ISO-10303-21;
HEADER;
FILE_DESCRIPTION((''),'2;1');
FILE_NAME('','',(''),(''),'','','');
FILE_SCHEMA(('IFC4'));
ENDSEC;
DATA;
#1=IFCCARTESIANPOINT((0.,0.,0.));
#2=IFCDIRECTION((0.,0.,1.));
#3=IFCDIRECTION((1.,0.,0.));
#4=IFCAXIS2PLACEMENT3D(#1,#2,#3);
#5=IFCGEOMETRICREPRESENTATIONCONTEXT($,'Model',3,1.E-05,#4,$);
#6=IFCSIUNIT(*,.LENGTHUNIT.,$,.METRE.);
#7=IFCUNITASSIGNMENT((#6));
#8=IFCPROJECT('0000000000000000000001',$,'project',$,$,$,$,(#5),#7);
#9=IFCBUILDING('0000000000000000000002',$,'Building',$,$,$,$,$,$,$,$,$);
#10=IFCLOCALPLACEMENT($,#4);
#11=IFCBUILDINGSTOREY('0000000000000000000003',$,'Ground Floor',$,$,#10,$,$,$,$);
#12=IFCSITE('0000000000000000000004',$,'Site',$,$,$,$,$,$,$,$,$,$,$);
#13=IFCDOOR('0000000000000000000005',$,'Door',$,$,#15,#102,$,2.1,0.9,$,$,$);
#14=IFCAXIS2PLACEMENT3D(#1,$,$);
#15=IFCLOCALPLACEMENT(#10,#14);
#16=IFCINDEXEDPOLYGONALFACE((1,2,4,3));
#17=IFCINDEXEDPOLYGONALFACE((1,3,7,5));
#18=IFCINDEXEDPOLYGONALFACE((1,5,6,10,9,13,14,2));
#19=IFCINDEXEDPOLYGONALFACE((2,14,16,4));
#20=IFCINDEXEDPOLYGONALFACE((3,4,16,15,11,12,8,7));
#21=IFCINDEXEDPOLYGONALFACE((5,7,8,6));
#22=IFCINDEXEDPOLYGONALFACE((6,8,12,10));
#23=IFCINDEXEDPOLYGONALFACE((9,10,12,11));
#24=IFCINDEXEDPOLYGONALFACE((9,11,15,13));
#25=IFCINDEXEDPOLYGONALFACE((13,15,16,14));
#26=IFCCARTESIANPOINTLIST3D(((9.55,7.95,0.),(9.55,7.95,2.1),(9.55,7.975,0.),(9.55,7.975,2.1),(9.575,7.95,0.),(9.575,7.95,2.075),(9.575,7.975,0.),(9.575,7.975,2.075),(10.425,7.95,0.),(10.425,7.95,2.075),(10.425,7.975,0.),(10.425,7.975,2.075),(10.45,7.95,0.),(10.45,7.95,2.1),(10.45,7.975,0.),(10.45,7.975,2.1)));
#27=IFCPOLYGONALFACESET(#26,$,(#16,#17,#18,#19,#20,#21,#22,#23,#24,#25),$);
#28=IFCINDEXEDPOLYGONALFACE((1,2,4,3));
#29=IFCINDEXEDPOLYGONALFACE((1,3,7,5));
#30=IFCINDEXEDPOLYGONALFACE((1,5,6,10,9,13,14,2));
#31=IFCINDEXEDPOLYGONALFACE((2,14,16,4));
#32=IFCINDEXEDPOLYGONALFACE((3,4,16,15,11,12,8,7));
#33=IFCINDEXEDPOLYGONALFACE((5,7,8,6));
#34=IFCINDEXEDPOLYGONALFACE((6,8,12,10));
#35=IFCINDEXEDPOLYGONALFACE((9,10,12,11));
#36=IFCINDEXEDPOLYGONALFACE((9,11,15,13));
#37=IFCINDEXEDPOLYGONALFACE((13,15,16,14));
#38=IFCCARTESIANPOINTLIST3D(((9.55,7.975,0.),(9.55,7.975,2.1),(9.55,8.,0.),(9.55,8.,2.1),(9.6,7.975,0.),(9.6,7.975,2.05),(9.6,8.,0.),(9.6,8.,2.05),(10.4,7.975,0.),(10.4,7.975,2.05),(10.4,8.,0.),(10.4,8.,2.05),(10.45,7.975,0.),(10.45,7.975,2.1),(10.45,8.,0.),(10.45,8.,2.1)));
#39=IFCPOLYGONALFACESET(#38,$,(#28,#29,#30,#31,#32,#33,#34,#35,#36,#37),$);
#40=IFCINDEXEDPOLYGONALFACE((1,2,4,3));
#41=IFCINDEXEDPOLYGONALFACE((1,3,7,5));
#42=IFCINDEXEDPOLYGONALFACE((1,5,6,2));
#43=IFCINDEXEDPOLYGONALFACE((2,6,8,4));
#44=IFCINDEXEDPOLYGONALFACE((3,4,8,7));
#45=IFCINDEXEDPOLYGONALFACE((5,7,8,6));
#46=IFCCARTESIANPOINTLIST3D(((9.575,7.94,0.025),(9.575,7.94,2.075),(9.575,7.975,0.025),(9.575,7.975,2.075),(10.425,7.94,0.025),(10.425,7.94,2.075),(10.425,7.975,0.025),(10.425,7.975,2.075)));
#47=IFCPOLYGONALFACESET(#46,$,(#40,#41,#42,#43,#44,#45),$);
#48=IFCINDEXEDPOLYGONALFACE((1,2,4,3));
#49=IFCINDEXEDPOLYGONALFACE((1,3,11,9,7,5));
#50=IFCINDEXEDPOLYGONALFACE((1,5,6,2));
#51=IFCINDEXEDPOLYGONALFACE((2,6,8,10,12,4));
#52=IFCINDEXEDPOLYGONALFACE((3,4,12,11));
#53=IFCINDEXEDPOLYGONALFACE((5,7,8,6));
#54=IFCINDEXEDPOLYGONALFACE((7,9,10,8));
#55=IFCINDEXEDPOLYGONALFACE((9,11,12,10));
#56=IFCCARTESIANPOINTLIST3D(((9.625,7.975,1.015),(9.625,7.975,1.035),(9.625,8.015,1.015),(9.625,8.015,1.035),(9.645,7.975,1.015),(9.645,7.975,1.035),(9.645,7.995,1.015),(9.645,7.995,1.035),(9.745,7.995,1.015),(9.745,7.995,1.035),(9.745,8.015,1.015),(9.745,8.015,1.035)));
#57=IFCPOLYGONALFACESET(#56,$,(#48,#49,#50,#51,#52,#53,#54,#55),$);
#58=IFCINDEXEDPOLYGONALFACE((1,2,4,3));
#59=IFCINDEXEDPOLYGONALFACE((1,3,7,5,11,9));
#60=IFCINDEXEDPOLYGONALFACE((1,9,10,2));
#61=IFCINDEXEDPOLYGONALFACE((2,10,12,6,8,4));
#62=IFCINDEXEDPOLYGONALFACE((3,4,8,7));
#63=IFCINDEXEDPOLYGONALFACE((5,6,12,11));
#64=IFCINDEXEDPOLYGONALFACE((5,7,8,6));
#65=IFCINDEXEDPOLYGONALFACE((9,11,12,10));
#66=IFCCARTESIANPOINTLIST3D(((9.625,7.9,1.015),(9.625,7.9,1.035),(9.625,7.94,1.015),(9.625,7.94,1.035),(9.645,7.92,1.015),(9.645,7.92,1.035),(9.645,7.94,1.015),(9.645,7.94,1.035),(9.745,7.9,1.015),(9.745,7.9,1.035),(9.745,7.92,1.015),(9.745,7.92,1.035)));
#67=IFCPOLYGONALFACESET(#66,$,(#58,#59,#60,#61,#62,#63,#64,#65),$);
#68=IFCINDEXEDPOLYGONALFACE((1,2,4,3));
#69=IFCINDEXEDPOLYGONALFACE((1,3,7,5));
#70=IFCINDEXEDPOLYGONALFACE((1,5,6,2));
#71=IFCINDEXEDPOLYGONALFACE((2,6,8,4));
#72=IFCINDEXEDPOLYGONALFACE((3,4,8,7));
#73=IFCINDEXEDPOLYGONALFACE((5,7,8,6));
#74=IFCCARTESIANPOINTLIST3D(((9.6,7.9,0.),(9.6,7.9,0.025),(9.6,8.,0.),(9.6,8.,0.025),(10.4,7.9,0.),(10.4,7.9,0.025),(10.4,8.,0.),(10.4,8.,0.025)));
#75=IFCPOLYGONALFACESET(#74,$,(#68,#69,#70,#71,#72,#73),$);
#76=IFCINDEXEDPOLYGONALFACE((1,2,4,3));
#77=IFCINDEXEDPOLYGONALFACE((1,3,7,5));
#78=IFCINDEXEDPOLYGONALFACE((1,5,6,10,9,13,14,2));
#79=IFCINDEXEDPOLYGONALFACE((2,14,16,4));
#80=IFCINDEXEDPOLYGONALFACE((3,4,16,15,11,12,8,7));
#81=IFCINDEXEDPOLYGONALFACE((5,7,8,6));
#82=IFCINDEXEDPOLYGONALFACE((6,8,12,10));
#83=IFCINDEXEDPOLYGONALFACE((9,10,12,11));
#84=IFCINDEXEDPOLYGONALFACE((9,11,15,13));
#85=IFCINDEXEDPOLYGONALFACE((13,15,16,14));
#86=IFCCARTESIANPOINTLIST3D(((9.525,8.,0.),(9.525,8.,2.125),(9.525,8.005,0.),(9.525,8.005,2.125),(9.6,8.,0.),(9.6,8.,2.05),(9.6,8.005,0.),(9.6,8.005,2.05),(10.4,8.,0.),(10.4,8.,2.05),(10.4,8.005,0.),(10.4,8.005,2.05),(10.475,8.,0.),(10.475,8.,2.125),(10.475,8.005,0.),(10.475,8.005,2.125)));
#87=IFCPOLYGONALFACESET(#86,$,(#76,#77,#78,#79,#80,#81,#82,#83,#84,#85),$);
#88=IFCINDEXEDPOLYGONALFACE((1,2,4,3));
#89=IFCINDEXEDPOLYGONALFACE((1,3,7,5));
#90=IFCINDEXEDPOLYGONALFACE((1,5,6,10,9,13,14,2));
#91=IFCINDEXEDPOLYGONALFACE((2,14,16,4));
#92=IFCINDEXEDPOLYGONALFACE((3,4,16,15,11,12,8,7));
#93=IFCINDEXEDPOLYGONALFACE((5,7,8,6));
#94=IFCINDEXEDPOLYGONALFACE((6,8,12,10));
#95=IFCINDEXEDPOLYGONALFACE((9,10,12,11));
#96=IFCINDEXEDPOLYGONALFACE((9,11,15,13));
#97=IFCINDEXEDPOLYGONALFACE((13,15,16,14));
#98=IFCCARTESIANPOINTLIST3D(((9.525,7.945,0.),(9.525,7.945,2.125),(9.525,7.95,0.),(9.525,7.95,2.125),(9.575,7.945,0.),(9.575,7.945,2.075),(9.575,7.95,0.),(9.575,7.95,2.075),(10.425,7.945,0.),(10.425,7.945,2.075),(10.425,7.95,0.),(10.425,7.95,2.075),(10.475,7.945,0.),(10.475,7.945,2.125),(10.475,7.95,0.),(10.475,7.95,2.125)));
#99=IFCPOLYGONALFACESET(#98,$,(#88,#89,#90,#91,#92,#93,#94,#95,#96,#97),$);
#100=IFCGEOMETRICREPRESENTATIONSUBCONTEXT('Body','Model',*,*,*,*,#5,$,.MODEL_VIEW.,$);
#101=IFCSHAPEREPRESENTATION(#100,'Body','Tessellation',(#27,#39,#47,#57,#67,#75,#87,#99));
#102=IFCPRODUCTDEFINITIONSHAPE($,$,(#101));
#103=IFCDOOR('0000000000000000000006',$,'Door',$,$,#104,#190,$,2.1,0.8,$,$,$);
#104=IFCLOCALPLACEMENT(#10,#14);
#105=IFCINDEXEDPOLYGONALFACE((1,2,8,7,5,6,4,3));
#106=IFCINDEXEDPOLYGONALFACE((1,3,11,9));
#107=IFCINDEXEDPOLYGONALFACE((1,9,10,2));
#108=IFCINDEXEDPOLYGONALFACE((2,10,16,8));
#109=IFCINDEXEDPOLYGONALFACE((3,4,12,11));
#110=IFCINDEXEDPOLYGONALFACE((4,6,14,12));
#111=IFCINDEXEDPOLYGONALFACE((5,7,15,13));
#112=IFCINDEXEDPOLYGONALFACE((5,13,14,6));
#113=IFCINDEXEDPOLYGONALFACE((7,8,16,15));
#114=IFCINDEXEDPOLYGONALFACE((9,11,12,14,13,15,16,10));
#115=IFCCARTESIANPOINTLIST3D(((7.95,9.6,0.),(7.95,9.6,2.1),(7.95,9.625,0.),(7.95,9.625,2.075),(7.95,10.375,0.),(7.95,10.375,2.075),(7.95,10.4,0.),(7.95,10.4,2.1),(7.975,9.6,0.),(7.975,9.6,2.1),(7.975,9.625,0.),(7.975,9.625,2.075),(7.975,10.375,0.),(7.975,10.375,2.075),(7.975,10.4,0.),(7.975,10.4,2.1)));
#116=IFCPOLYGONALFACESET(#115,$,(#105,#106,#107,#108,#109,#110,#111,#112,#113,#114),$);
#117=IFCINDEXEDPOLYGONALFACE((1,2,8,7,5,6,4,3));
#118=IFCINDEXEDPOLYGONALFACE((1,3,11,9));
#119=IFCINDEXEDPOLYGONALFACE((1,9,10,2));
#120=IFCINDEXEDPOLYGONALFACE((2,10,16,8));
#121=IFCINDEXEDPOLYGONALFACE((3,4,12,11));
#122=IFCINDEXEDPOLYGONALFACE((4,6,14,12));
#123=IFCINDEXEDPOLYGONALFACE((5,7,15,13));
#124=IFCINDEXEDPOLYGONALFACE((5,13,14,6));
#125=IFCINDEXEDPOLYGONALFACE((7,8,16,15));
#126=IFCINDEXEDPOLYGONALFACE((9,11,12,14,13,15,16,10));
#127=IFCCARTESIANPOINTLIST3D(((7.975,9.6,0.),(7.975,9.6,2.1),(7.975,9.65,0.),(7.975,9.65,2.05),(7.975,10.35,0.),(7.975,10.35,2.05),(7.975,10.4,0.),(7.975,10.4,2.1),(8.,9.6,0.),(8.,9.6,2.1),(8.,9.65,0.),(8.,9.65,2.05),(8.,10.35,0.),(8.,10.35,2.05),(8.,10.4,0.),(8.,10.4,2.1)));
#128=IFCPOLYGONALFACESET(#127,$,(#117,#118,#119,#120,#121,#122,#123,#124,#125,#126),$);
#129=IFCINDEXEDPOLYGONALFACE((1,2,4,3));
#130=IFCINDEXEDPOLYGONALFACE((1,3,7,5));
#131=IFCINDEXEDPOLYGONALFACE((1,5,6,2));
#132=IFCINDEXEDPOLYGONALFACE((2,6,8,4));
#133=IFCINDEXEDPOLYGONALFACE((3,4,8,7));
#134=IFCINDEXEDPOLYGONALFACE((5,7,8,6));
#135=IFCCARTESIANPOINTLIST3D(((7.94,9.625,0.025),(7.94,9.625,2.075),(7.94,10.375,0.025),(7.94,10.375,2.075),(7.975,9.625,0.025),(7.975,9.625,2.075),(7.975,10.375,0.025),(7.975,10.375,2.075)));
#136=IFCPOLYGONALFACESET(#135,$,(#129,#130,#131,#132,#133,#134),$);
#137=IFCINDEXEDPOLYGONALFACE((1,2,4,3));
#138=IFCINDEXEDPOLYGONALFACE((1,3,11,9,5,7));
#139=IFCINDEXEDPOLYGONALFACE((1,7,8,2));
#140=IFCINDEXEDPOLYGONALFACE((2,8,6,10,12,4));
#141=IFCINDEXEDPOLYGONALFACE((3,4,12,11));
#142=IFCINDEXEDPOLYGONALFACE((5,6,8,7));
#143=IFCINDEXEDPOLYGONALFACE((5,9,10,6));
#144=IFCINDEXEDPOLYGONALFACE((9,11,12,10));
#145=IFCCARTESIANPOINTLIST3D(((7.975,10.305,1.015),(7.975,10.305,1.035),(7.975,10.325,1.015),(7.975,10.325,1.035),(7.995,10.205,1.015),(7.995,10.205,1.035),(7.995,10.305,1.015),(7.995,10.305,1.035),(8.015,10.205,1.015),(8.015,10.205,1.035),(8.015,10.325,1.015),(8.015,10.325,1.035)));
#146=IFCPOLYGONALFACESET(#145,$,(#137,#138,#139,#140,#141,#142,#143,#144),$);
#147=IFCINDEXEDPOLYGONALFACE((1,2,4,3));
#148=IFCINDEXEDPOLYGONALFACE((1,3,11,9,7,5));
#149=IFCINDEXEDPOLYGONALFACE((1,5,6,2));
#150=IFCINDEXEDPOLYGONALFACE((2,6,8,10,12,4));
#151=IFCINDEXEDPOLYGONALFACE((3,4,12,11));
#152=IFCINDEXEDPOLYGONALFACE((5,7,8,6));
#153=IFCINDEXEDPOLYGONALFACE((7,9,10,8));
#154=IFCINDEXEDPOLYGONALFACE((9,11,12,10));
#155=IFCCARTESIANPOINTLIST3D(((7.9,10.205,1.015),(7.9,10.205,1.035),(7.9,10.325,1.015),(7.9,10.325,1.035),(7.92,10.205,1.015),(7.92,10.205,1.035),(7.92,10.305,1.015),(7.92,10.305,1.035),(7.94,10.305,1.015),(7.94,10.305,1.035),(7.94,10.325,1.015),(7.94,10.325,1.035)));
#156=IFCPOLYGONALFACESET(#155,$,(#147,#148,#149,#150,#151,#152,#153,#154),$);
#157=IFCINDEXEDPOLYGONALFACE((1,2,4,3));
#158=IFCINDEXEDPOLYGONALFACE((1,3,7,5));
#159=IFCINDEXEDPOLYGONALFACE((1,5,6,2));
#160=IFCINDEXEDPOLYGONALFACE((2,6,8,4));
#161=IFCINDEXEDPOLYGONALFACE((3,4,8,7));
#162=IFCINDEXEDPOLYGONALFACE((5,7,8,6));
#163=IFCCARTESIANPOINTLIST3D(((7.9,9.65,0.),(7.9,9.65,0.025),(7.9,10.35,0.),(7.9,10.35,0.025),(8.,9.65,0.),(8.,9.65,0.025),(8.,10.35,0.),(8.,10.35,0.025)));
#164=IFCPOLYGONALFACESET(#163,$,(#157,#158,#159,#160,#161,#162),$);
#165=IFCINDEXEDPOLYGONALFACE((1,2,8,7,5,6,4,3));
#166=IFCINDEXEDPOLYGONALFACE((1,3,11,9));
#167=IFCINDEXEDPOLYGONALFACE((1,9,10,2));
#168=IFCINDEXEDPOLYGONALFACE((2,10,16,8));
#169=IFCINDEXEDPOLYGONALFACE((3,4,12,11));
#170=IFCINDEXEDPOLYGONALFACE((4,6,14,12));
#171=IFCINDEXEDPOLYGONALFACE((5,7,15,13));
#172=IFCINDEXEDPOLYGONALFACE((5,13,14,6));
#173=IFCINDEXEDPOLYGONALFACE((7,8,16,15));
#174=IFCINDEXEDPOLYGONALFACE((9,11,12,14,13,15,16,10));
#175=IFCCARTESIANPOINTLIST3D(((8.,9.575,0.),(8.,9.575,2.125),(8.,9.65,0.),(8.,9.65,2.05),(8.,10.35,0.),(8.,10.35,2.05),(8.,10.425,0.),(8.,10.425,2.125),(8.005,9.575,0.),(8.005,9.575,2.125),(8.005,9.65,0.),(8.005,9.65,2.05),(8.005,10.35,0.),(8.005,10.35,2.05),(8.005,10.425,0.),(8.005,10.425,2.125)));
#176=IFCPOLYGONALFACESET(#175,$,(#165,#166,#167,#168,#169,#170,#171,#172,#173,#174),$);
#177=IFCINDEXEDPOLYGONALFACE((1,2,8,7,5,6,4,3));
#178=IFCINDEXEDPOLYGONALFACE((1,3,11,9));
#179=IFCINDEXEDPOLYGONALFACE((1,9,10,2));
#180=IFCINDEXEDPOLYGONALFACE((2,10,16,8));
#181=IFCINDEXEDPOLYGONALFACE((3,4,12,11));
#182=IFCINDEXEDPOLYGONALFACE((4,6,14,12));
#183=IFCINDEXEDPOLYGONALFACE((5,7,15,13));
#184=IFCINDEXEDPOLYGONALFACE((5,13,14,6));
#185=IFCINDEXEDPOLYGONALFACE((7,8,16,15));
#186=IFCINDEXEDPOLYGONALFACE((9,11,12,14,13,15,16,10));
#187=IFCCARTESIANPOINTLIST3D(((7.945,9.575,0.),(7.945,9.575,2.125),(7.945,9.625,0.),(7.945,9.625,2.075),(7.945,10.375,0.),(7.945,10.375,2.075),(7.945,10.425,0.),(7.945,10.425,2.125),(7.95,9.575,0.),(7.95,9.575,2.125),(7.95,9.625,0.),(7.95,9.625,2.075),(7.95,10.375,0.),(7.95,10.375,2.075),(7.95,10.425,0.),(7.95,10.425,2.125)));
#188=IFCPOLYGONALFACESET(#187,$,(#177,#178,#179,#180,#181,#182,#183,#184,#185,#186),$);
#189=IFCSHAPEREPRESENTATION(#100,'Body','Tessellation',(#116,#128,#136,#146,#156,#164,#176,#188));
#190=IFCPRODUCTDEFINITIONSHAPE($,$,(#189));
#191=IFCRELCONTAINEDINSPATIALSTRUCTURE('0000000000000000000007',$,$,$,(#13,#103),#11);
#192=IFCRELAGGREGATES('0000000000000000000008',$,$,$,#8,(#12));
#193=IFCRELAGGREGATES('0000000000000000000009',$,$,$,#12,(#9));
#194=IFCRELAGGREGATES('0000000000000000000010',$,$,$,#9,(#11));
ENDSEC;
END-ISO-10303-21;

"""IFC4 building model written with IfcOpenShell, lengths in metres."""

from ifc_helpers import new_model, si_unit, frame, origin_with_axes, place, context, subcontext, project, spatial, line, indexed_curve, outline, extrude, element, save


model = new_model("IFC4")

# Units and contexts
model_context = context("Model", 3, precision=1e-05, world=origin_with_axes())
body_context = subcontext(model_context, "Body", "Model", "MODEL_VIEW")
ifc_project = project(units=[si_unit("LENGTHUNIT", "METRE")], contexts=[model_context])

# Site, building, storey
site = spatial("IfcSite", under=ifc_project, Name="Site")
building = spatial("IfcBuilding", under=site, Name="Building")
storey_placement = place(None, origin_with_axes())
storey = spatial("IfcBuildingStorey", under=building, at=storey_placement, Name="Ground Floor")

# Doors
door_1_placement = place(storey_placement, frame((10.45, 8.0, 0.0), z_axis=(0.0, 0.0, 1.0), x_axis=(-1.0, 0.0, 0.0)))
element("IfcDoor", 1, at=door_1_placement, inside=storey, Name="Door", OverallHeight=2.1, OverallWidth=0.9, context=body_context, shape_type="SweptSolid", body=[
    extrude(outline(indexed_curve([(0.0, 0.0), (0.0, 2.1), (0.9, 2.1), (0.9, 0.0), (0.875, 0.0), (0.875, 2.075), (0.025, 2.075), (0.025, 0.0)], segments=[line(1, 2, 3, 4, 5, 6, 7, 8, 1)])), frame((0.0, 0.025, 0.0), z_axis=(0.0, -1.0, 0.0), x_axis=(1.0, 0.0, 0.0)), (0.0, 0.0, -1.0), 0.025),
    extrude(outline(indexed_curve([(0.0, 0.0), (0.0, 2.1), (0.9, 2.1), (0.9, 0.0), (0.85, 0.0), (0.85, 2.05), (0.05, 2.05), (0.05, 0.0)], segments=[line(1, 2, 3, 4, 5, 6, 7, 8, 1)])), frame((0.0, 0.0, 0.0), z_axis=(0.0, -1.0, 0.0), x_axis=(1.0, 0.0, 0.0)), (0.0, 0.0, -1.0), 0.025),
    extrude(outline(indexed_curve([(0.0, 0.0), (0.85, 0.0), (0.85, 0.035), (0.0, 0.035)], segments=[line(1, 2, 3, 4, 1)])), frame((0.025, 0.025, 0.025), z_axis=(0.0, 0.0, 1.0), x_axis=(1.0, 0.0, 0.0)), (0.0, 0.0, 1.0), 2.05),
    extrude(outline(indexed_curve([(0.0, 0.0), (0.0, -0.04), (-0.12, -0.04), (-0.12, -0.02), (-0.02, -0.02), (-0.02, 0.0)], segments=[line(1, 2, 3, 4, 5, 6, 1)])), frame((0.825, 0.025, 1.015), z_axis=(0.0, 0.0, 1.0), x_axis=(1.0, 0.0, 0.0)), (0.0, 0.0, 1.0), 0.02),
    extrude(outline(indexed_curve([(0.0, 0.0), (0.0, 0.04), (-0.12, 0.04), (-0.12, 0.02), (-0.02, 0.02), (-0.02, 0.0)], segments=[line(1, 2, 3, 4, 5, 6, 1)])), frame((0.825, 0.06, 1.015), z_axis=(0.0, 0.0, 1.0), x_axis=(1.0, 0.0, 0.0)), (0.0, 0.0, 1.0), 0.02),
    extrude(outline(indexed_curve([(0.0, 0.0), (0.8, 0.0), (0.8, 0.1), (0.0, 0.1)], segments=[line(1, 2, 3, 4, 1)])), frame((0.05, 0.0, 0.0), z_axis=(0.0, 0.0, 1.0), x_axis=(1.0, 0.0, 0.0)), (0.0, 0.0, 1.0), 0.025),
    extrude(outline(indexed_curve([(0.0, 0.0), (0.0, 2.125), (0.95, 2.125), (0.95, 0.0), (0.875, 0.0), (0.875, 2.05), (0.075, 2.05), (0.075, 0.0)], segments=[line(1, 2, 3, 4, 5, 6, 7, 8, 1)])), frame((-0.025, -0.005, 0.0), z_axis=(0.0, -1.0, 0.0), x_axis=(1.0, 0.0, 0.0)), (0.0, 0.0, -1.0), 0.005),
    extrude(outline(indexed_curve([(0.0, 0.0), (0.0, 2.125), (0.95, 2.125), (0.95, 0.0), (0.9, 0.0), (0.9, 2.075), (0.05, 2.075), (0.05, 0.0)], segments=[line(1, 2, 3, 4, 5, 6, 7, 8, 1)])), frame((-0.025, 0.05, 0.0), z_axis=(0.0, -1.0, 0.0), x_axis=(1.0, 0.0, 0.0)), (0.0, 0.0, -1.0), 0.005),
])
door_2_placement = place(storey_placement, frame((8.0, 9.6, 0.0), z_axis=(0.0, 0.0, 1.0), x_axis=(0.0, 1.0, 0.0)))
element("IfcDoor", 2, at=door_2_placement, inside=storey, Name="Door", OverallHeight=2.1, OverallWidth=0.8, context=body_context, shape_type="SweptSolid", body=[
    extrude(outline(indexed_curve([(0.0, 0.0), (0.0, 2.1), (0.8, 2.1), (0.8, 0.0), (0.775, 0.0), (0.775, 2.075), (0.025, 2.075), (0.025, 0.0)], segments=[line(1, 2, 3, 4, 5, 6, 7, 8, 1)])), frame((0.0, 0.025, 0.0), z_axis=(0.0, -1.0, 0.0), x_axis=(1.0, 0.0, 0.0)), (0.0, 0.0, -1.0), 0.025),
    extrude(outline(indexed_curve([(0.0, 0.0), (0.0, 2.1), (0.8, 2.1), (0.8, 0.0), (0.75, 0.0), (0.75, 2.05), (0.05, 2.05), (0.05, 0.0)], segments=[line(1, 2, 3, 4, 5, 6, 7, 8, 1)])), frame((0.0, 0.0, 0.0), z_axis=(0.0, -1.0, 0.0), x_axis=(1.0, 0.0, 0.0)), (0.0, 0.0, -1.0), 0.025),
    extrude(outline(indexed_curve([(0.0, 0.0), (0.75, 0.0), (0.75, 0.035), (0.0, 0.035)], segments=[line(1, 2, 3, 4, 1)])), frame((0.025, 0.025, 0.025), z_axis=(0.0, 0.0, 1.0), x_axis=(1.0, 0.0, 0.0)), (0.0, 0.0, 1.0), 2.05),
    extrude(outline(indexed_curve([(0.0, 0.0), (0.0, -0.04), (-0.12, -0.04), (-0.12, -0.02), (-0.02, -0.02), (-0.02, 0.0)], segments=[line(1, 2, 3, 4, 5, 6, 1)])), frame((0.725, 0.025, 1.015), z_axis=(0.0, 0.0, 1.0), x_axis=(1.0, 0.0, 0.0)), (0.0, 0.0, 1.0), 0.02),
    extrude(outline(indexed_curve([(0.0, 0.0), (0.0, 0.04), (-0.12, 0.04), (-0.12, 0.02), (-0.02, 0.02), (-0.02, 0.0)], segments=[line(1, 2, 3, 4, 5, 6, 1)])), frame((0.725, 0.06, 1.015), z_axis=(0.0, 0.0, 1.0), x_axis=(1.0, 0.0, 0.0)), (0.0, 0.0, 1.0), 0.02),
    extrude(outline(indexed_curve([(0.0, 0.0), (0.7, 0.0), (0.7, 0.1), (0.0, 0.1)], segments=[line(1, 2, 3, 4, 1)])), frame((0.05, 0.0, 0.0), z_axis=(0.0, 0.0, 1.0), x_axis=(1.0, 0.0, 0.0)), (0.0, 0.0, 1.0), 0.025),
    extrude(outline(indexed_curve([(0.0, 0.0), (0.0, 2.125), (0.85, 2.125), (0.85, 0.0), (0.775, 0.0), (0.775, 2.05), (0.075, 2.05), (0.075, 0.0)], segments=[line(1, 2, 3, 4, 5, 6, 7, 8, 1)])), frame((-0.025, -0.005, 0.0), z_axis=(0.0, -1.0, 0.0), x_axis=(1.0, 0.0, 0.0)), (0.0, 0.0, -1.0), 0.005),
    extrude(outline(indexed_curve([(0.0, 0.0), (0.0, 2.125), (0.85, 2.125), (0.85, 0.0), (0.8, 0.0), (0.8, 2.075), (0.05, 2.075), (0.05, 0.0)], segments=[line(1, 2, 3, 4, 5, 6, 7, 8, 1)])), frame((-0.025, 0.05, 0.0), z_axis=(0.0, -1.0, 0.0), x_axis=(1.0, 0.0, 0.0)), (0.0, 0.0, -1.0), 0.005),
])

save(model, "model.ifc")
